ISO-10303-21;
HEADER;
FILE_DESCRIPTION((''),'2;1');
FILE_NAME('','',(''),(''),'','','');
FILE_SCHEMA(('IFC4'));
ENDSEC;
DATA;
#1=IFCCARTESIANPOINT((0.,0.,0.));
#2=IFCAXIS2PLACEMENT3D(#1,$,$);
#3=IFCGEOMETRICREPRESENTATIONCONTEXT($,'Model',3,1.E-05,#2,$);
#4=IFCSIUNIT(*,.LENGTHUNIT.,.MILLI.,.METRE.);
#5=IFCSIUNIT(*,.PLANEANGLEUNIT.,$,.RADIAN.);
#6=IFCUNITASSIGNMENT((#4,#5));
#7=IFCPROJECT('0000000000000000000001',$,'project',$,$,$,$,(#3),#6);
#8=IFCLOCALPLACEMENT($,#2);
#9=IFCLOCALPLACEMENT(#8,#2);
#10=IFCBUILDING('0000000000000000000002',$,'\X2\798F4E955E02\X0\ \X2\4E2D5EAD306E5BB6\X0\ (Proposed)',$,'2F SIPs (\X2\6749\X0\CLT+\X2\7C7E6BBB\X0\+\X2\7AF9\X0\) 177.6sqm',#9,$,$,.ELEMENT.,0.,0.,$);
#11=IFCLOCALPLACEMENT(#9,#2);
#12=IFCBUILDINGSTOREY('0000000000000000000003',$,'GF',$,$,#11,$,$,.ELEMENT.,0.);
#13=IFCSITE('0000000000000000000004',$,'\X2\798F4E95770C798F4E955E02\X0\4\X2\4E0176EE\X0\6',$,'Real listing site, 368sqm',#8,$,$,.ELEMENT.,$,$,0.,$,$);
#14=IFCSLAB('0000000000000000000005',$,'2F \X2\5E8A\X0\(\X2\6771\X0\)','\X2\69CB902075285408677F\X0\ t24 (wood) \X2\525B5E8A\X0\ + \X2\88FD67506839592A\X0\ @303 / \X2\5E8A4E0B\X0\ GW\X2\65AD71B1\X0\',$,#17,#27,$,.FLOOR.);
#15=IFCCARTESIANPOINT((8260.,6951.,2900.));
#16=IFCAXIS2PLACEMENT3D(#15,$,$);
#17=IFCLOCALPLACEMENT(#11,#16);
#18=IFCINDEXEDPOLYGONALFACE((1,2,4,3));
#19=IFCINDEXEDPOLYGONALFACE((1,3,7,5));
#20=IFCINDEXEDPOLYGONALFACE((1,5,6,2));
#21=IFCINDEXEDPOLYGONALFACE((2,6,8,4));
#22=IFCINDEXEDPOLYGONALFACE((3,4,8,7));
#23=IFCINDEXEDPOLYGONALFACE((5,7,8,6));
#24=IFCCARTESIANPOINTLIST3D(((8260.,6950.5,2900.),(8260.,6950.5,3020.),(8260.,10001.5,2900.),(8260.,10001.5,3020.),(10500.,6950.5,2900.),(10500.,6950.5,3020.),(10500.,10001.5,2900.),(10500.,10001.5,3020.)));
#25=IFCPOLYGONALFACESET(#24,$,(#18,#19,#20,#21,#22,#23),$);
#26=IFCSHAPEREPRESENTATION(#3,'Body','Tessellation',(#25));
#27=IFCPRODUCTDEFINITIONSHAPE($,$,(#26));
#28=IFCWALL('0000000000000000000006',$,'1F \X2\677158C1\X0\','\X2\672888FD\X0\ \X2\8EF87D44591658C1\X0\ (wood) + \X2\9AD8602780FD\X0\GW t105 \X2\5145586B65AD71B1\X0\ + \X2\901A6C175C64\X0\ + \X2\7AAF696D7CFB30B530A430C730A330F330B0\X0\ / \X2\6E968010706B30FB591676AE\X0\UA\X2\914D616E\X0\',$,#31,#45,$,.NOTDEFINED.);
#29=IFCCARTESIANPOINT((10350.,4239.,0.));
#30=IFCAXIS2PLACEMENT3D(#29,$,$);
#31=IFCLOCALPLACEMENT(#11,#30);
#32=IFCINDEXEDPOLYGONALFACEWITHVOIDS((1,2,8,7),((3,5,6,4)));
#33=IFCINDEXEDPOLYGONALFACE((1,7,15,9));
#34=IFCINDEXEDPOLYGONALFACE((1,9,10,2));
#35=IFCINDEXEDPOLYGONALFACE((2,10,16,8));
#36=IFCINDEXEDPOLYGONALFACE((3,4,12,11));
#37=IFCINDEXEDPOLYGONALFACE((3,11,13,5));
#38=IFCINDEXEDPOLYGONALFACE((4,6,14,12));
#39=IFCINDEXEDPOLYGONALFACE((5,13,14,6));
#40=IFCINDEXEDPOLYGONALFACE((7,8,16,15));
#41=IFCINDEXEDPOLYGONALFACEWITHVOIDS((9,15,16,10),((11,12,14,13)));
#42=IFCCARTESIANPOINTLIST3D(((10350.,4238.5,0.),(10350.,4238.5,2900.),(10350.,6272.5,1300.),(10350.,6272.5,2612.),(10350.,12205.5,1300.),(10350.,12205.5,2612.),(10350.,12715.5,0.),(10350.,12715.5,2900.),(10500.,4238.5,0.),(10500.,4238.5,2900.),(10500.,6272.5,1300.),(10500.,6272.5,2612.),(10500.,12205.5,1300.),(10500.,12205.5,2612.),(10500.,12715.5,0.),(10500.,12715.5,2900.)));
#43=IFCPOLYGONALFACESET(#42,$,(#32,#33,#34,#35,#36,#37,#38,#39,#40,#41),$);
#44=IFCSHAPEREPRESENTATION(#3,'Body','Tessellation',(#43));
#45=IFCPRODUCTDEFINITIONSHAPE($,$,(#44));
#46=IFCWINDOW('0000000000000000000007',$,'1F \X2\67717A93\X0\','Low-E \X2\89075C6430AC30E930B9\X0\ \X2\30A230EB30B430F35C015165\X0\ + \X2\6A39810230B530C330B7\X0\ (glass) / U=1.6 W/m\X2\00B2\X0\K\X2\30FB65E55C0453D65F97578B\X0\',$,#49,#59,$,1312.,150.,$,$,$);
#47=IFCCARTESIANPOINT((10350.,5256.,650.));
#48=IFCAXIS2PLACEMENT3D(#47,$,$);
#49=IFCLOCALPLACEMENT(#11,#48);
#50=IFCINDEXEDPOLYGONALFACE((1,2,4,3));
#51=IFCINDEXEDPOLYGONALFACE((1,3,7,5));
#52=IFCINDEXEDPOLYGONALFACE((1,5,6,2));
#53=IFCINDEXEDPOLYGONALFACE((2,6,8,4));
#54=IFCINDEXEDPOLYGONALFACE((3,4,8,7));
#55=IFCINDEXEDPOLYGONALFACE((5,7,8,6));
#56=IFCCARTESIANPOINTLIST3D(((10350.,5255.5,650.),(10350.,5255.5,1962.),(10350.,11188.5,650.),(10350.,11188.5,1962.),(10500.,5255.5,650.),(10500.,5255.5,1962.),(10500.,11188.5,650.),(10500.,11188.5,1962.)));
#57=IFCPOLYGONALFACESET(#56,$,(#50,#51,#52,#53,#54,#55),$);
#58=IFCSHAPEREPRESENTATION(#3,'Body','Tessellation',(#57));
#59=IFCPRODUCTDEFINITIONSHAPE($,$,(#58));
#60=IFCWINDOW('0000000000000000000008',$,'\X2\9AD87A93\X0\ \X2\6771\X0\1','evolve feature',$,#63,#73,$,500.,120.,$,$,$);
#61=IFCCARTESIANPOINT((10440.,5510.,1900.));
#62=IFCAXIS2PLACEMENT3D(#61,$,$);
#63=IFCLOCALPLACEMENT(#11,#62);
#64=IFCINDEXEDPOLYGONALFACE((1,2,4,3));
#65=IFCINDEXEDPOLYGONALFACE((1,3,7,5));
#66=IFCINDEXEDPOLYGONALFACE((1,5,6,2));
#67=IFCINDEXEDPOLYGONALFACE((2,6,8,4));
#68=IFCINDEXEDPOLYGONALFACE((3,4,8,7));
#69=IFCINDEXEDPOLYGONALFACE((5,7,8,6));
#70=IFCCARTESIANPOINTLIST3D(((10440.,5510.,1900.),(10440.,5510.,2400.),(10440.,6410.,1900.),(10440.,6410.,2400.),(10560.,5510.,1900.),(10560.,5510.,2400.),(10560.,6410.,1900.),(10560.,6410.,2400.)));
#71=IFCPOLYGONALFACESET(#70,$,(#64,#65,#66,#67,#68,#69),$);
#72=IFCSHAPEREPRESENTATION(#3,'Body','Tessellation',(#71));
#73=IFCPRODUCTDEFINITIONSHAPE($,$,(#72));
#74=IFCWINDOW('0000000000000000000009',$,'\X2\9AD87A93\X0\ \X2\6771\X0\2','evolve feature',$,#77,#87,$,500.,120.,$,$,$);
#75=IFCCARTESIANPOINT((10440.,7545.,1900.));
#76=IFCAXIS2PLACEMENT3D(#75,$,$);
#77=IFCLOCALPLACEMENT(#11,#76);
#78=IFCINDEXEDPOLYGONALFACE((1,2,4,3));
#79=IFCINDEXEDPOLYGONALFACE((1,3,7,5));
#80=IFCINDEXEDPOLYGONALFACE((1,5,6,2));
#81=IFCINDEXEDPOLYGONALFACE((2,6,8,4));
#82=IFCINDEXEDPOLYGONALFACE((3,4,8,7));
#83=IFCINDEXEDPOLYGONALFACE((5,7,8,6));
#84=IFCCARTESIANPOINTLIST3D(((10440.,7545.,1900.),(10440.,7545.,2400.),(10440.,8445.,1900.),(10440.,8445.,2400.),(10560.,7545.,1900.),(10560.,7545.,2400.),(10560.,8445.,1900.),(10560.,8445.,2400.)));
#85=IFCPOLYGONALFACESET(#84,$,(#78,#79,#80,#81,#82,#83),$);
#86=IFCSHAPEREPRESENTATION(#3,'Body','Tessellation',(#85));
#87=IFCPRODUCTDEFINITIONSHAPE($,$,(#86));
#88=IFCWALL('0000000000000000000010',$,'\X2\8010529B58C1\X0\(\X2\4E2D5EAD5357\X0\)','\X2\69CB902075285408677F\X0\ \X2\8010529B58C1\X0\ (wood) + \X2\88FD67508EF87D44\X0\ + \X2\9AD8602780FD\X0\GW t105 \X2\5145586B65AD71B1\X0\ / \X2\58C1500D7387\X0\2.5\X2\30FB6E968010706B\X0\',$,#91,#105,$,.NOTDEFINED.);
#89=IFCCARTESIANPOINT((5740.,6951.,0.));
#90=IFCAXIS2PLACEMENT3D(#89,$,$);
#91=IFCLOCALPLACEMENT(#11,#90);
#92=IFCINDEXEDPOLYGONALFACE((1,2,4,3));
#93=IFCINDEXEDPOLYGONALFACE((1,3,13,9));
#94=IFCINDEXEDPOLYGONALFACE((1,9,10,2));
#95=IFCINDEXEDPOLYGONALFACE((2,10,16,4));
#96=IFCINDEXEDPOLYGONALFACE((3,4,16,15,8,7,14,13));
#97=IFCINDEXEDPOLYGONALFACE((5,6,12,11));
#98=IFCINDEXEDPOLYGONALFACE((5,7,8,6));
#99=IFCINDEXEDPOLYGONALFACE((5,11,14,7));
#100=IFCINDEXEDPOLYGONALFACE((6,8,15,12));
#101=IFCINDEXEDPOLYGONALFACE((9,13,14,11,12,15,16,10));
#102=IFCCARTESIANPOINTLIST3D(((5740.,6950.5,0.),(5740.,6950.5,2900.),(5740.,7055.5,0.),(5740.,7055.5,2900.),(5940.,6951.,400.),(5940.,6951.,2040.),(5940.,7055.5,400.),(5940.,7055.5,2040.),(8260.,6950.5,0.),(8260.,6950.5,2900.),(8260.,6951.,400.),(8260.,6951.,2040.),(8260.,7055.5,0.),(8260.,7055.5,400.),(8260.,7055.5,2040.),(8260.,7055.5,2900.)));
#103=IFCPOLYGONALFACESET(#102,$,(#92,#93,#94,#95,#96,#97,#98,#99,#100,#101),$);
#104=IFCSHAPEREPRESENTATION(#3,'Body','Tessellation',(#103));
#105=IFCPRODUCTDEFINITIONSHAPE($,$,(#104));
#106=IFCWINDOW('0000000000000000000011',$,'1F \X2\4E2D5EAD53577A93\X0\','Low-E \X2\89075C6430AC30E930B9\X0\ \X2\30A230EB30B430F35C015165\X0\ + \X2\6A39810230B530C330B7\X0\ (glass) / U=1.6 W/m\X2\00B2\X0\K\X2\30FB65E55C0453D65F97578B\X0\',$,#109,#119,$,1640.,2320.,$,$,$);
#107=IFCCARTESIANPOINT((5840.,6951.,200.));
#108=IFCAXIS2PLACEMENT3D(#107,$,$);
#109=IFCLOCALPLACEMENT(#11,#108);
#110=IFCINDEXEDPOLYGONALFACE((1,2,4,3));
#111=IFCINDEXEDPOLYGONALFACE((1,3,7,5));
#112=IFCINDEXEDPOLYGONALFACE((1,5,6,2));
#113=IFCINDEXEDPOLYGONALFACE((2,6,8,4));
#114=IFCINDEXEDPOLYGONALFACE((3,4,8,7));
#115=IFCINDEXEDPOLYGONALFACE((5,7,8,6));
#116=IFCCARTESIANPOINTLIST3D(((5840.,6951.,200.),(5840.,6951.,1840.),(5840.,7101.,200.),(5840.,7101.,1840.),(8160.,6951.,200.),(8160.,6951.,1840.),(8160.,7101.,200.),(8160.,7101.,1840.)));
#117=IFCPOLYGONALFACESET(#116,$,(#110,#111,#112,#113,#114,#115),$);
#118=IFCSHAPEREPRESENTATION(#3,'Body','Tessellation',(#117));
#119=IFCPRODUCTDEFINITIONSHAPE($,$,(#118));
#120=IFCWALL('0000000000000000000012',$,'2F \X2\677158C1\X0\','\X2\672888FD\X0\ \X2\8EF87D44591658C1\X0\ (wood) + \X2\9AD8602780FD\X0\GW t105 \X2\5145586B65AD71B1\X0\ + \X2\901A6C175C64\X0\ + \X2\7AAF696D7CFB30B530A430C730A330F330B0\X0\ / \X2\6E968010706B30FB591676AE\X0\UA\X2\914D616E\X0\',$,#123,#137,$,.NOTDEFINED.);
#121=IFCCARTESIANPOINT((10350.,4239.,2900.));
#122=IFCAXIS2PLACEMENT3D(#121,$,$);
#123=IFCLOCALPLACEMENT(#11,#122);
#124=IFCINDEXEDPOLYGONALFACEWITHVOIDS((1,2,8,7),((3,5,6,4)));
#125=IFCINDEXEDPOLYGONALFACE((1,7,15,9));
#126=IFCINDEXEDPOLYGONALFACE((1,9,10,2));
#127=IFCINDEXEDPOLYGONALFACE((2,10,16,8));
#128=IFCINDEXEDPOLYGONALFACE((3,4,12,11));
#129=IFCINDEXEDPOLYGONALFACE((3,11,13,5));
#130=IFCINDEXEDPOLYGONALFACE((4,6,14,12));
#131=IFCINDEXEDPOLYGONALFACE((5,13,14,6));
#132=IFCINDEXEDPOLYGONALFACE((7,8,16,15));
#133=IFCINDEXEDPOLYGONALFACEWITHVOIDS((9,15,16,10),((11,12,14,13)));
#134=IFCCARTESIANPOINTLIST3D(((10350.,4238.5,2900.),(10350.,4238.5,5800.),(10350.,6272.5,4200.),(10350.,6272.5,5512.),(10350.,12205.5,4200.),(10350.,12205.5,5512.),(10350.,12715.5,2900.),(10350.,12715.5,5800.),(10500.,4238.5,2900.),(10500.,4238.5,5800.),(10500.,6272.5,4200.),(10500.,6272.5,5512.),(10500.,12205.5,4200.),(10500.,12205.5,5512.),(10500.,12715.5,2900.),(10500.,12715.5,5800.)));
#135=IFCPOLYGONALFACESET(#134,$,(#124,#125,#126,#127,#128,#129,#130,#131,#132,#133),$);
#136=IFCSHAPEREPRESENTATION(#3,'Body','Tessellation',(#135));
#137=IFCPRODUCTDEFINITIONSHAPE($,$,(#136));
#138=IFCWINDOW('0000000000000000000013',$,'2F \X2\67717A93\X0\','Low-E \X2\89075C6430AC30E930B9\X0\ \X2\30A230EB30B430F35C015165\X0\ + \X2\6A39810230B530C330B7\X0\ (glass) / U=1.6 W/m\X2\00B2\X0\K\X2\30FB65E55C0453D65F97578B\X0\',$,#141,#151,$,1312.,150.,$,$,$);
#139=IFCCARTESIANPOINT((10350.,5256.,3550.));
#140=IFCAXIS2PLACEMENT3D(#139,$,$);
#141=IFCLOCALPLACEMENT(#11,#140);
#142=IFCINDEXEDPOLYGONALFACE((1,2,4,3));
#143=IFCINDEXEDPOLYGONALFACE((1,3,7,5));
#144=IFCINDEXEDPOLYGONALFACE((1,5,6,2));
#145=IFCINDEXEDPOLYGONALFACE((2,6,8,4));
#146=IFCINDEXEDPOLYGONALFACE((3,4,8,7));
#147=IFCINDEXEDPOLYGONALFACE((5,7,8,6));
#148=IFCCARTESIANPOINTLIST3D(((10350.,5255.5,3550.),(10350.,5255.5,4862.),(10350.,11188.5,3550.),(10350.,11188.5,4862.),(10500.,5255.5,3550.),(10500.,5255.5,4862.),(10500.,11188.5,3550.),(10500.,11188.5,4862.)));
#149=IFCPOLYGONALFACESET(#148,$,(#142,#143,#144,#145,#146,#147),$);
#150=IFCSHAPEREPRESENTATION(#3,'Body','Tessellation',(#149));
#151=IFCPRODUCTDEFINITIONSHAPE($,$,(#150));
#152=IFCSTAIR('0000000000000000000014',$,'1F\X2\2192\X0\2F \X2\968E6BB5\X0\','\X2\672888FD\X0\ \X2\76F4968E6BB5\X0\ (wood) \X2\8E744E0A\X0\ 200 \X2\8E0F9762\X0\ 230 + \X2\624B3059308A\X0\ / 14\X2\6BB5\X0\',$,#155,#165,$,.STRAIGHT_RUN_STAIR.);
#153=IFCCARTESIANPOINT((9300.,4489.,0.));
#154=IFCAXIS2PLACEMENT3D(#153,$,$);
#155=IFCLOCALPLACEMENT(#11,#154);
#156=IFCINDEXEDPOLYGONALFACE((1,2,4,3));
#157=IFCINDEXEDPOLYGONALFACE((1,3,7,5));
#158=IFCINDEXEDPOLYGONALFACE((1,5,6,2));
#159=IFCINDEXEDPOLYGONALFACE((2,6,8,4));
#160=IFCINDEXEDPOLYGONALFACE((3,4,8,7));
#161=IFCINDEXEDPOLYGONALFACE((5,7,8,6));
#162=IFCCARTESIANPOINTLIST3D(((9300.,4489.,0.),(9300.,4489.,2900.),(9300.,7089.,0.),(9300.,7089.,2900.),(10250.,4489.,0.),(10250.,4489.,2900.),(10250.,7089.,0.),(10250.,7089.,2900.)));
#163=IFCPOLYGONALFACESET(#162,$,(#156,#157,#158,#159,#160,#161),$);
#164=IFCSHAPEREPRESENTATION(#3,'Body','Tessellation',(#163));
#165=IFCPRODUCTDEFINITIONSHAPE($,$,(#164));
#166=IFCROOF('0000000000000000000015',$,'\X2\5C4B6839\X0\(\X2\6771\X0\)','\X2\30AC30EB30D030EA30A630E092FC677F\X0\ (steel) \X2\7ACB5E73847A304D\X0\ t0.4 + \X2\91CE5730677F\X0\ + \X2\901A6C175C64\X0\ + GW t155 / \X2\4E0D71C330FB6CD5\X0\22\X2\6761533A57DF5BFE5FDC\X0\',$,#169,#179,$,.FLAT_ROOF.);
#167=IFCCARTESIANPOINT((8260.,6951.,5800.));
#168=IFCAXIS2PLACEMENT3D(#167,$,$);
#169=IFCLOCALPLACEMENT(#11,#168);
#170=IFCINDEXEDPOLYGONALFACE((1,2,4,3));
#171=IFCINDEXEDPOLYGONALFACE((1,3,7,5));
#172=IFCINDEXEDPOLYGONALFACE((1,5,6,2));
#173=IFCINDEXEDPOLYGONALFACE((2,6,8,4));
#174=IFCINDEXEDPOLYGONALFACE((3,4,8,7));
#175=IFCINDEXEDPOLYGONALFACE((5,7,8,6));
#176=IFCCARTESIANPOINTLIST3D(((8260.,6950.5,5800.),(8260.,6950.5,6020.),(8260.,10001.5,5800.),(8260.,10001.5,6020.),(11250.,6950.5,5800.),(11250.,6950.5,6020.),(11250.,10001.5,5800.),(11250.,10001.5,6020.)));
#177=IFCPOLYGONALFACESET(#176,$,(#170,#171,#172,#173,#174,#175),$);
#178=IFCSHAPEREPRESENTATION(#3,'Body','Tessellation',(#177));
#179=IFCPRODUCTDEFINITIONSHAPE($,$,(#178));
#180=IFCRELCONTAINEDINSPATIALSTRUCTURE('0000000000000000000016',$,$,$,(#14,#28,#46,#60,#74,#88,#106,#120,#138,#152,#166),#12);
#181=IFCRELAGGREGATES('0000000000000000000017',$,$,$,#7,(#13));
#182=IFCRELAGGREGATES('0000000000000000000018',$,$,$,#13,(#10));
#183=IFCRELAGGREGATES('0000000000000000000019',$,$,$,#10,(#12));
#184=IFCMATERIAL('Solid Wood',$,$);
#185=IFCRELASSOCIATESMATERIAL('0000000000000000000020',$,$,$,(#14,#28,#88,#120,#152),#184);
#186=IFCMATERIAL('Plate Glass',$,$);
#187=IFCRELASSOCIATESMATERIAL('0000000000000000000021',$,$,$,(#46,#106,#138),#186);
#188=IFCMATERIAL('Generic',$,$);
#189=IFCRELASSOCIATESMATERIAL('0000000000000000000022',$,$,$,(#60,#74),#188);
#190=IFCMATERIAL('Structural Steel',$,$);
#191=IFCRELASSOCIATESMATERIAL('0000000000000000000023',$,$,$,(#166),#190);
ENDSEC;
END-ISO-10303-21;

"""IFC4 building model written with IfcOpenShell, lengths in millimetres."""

from ifc_helpers import new_model, si_unit, frame, frame_2d, origin, place, context, project, spatial, rectangle, extrude, material, element, fill, save


model = new_model("IFC4")

# Units and contexts
model_context = context("Model", 3, precision=1e-05, world=origin())
ifc_project = project(units=[si_unit("LENGTHUNIT", "METRE", prefix="MILLI"), si_unit("PLANEANGLEUNIT", "RADIAN")], contexts=[model_context])

# Site, building, storey
site_placement = place(None, origin())
site = spatial("IfcSite", under=ifc_project, at=site_placement, Name="福井県福井市4丁目6", ObjectType="Real listing site, 368sqm", CompositionType="ELEMENT", RefElevation=0.0)
building_placement = place(site_placement, origin())
building = spatial("IfcBuilding", under=site, at=building_placement, Name="福井市 中庭の家 (Proposed)", ObjectType="2F SIPs (杉CLT+籾殻+竹) 177.6sqm", CompositionType="ELEMENT", ElevationOfRefHeight=0.0, ElevationOfTerrain=0.0)
storey_placement = place(building_placement, origin())
storey = spatial("IfcBuildingStorey", under=building, at=storey_placement, Name="GF", CompositionType="ELEMENT", Elevation=0.0)

# Slab
ifc_material_1 = material(Name="Solid Wood")
slab_1_placement = place(storey_placement, frame((8260.0, 6951.0, 2900.0)))
element("IfcSlab", 1, at=slab_1_placement, inside=storey, material=ifc_material_1, Name="2F 床(東)", Description="構造用合板 t24 (wood) 剛床 + 製材根太 @303 / 床下 GW断熱", PredefinedType="FLOOR", context=model_context, shape_type="SweptSolid", body=[
    extrude(rectangle(XDim=2240.0, YDim=3051.0, at=frame_2d((1120.0, 1525.0))), frame((8260.0, 6951.0, 2900.0)), (0.0, 0.0, 1.0), 120.0),
])

# Wall, openings, windows
wall_1_placement = place(storey_placement, frame((10350.0, 4239.0, 0.0)))
wall_1 = element("IfcWall", 2, at=wall_1_placement, inside=storey, material=ifc_material_1, Name="1F 東壁", Description="木製 軸組外壁 (wood) + 高性能GW t105 充填断熱 + 通気層 + 窯業系サイディング / 準耐火・外皮UA配慮", PredefinedType="NOTDEFINED", context=model_context, shape_type="SweptSolid", body=[
    extrude(rectangle(XDim=150.0, YDim=8477.0, at=frame_2d((75.0, 4238.0))), frame((10350.0, 4239.0, 0.0)), (0.0, 0.0, 1.0), 2900.0),
])
opening_1_placement = place(storey_placement, frame((10350.0, 5256.0, 650.0)))
opening_1 = element("IfcOpeningElement", 3, at=opening_1_placement, cuts=wall_1, PredefinedType="NOTDEFINED", context=model_context, shape_type="SweptSolid", body=[
    extrude(rectangle(XDim=150.0, YDim=5933.0, at=frame_2d((75.0, 2966.0))), frame((10350.0, 5256.0, 650.0)), (0.0, 0.0, 1.0), 1312.0),
])
opening_2_placement = place(storey_placement, frame((10440.0, 5510.0, 1900.0)))
opening_2 = element("IfcOpeningElement", 4, at=opening_2_placement, cuts=wall_1, PredefinedType="NOTDEFINED", context=model_context, shape_type="SweptSolid", body=[
    extrude(rectangle(XDim=120.0, YDim=900.0, at=frame_2d((60.0, 450.0))), frame((10440.0, 5510.0, 1900.0)), (0.0, 0.0, 1.0), 500.0),
])
opening_3_placement = place(storey_placement, frame((10440.0, 7545.0, 1900.0)))
opening_3 = element("IfcOpeningElement", 5, at=opening_3_placement, cuts=wall_1, PredefinedType="NOTDEFINED", context=model_context, shape_type="SweptSolid", body=[
    extrude(rectangle(XDim=120.0, YDim=900.0, at=frame_2d((60.0, 450.0))), frame((10440.0, 7545.0, 1900.0)), (0.0, 0.0, 1.0), 500.0),
])
ifc_material_2 = material(Name="Plate Glass")
window_1_placement = place(storey_placement, frame((10350.0, 5256.0, 650.0)))
window_1 = element("IfcWindow", 6, at=window_1_placement, inside=storey, material=ifc_material_2, Name="1F 東窓", Description="Low-E 複層ガラス アルゴン封入 + 樹脂サッシ (glass) / U=1.6 W/m²K・日射取得型", OverallHeight=1312.0, OverallWidth=150.0, context=model_context, shape_type="SweptSolid", body=[
    extrude(rectangle(XDim=150.0, YDim=5933.0, at=frame_2d((75.0, 2966.0))), frame((10350.0, 5256.0, 650.0)), (0.0, 0.0, 1.0), 1312.0),
])
fill(opening_1, window_1)
ifc_material_3 = material(Name="Generic")
window_2_placement = place(storey_placement, frame((10440.0, 5510.0, 1900.0)))
window_2 = element("IfcWindow", 7, at=window_2_placement, inside=storey, material=ifc_material_3, Name="高窓 東1", Description="evolve feature", OverallHeight=500.0, OverallWidth=120.0, context=model_context, shape_type="SweptSolid", body=[
    extrude(rectangle(XDim=120.0, YDim=900.0, at=frame_2d((60.0, 450.0))), frame((10440.0, 5510.0, 1900.0)), (0.0, 0.0, 1.0), 500.0),
])
fill(opening_2, window_2)
window_3_placement = place(storey_placement, frame((10440.0, 7545.0, 1900.0)))
window_3 = element("IfcWindow", 8, at=window_3_placement, inside=storey, material=ifc_material_3, Name="高窓 東2", Description="evolve feature", OverallHeight=500.0, OverallWidth=120.0, context=model_context, shape_type="SweptSolid", body=[
    extrude(rectangle(XDim=120.0, YDim=900.0, at=frame_2d((60.0, 450.0))), frame((10440.0, 7545.0, 1900.0)), (0.0, 0.0, 1.0), 500.0),
])
fill(opening_3, window_3)

# Wall, opening, window
wall_2_placement = place(storey_placement, frame((5740.0, 6951.0, 0.0)))
wall_2 = element("IfcWall", 9, at=wall_2_placement, inside=storey, material=ifc_material_1, Name="耐力壁(中庭南)", Description="構造用合板 耐力壁 (wood) + 製材軸組 + 高性能GW t105 充填断熱 / 壁倍率2.5・準耐火", PredefinedType="NOTDEFINED", context=model_context, shape_type="SweptSolid", body=[
    extrude(rectangle(XDim=2520.0, YDim=105.0, at=frame_2d((1260.0, 52.0))), frame((5740.0, 6951.0, 0.0)), (0.0, 0.0, 1.0), 2900.0),
])
opening_4_placement = place(storey_placement, frame((5840.0, 6951.0, 200.0)))
opening_4 = element("IfcOpeningElement", 10, at=opening_4_placement, cuts=wall_2, PredefinedType="NOTDEFINED", context=model_context, shape_type="SweptSolid", body=[
    extrude(rectangle(XDim=2320.0, YDim=150.0, at=frame_2d((1160.0, 75.0))), frame((5840.0, 6951.0, 200.0)), (0.0, 0.0, 1.0), 1640.0),
])
window_4_placement = place(storey_placement, frame((5840.0, 6951.0, 200.0)))
window_4 = element("IfcWindow", 11, at=window_4_placement, inside=storey, material=ifc_material_2, Name="1F 中庭南窓", Description="Low-E 複層ガラス アルゴン封入 + 樹脂サッシ (glass) / U=1.6 W/m²K・日射取得型", OverallHeight=1640.0, OverallWidth=2320.0, context=model_context, shape_type="SweptSolid", body=[
    extrude(rectangle(XDim=2320.0, YDim=150.0, at=frame_2d((1160.0, 75.0))), frame((5840.0, 6951.0, 200.0)), (0.0, 0.0, 1.0), 1640.0),
])
fill(opening_4, window_4)

# Wall, opening, window
wall_3_placement = place(storey_placement, frame((10350.0, 4239.0, 2900.0)))
wall_3 = element("IfcWall", 12, at=wall_3_placement, inside=storey, material=ifc_material_1, Name="2F 東壁", Description="木製 軸組外壁 (wood) + 高性能GW t105 充填断熱 + 通気層 + 窯業系サイディング / 準耐火・外皮UA配慮", PredefinedType="NOTDEFINED", context=model_context, shape_type="SweptSolid", body=[
    extrude(rectangle(XDim=150.0, YDim=8477.0, at=frame_2d((75.0, 4238.0))), frame((10350.0, 4239.0, 2900.0)), (0.0, 0.0, 1.0), 2900.0),
])
opening_5_placement = place(storey_placement, frame((10350.0, 5256.0, 3550.0)))
opening_5 = element("IfcOpeningElement", 13, at=opening_5_placement, cuts=wall_3, PredefinedType="NOTDEFINED", context=model_context, shape_type="SweptSolid", body=[
    extrude(rectangle(XDim=150.0, YDim=5933.0, at=frame_2d((75.0, 2966.0))), frame((10350.0, 5256.0, 3550.0)), (0.0, 0.0, 1.0), 1312.0),
])
window_5_placement = place(storey_placement, frame((10350.0, 5256.0, 3550.0)))
window_5 = element("IfcWindow", 14, at=window_5_placement, inside=storey, material=ifc_material_2, Name="2F 東窓", Description="Low-E 複層ガラス アルゴン封入 + 樹脂サッシ (glass) / U=1.6 W/m²K・日射取得型", OverallHeight=1312.0, OverallWidth=150.0, context=model_context, shape_type="SweptSolid", body=[
    extrude(rectangle(XDim=150.0, YDim=5933.0, at=frame_2d((75.0, 2966.0))), frame((10350.0, 5256.0, 3550.0)), (0.0, 0.0, 1.0), 1312.0),
])
fill(opening_5, window_5)

# Stair
stair_placement = place(storey_placement, frame((9300.0, 4489.0, 0.0)))
element("IfcStair", 15, at=stair_placement, inside=storey, material=ifc_material_1, Name="1F→2F 階段", Description="木製 直階段 (wood) 蹴上 200 踏面 230 + 手すり / 14段", PredefinedType="STRAIGHT_RUN_STAIR", context=model_context, shape_type="SweptSolid", body=[
    extrude(rectangle(XDim=950.0, YDim=2600.0, at=frame_2d((475.0, 1300.0))), frame((9300.0, 4489.0, 0.0)), (0.0, 0.0, 1.0), 2900.0),
])

# Roof
ifc_material_4 = material(Name="Structural Steel")
roof_placement = place(storey_placement, frame((8260.0, 6951.0, 5800.0)))
element("IfcRoof", 16, at=roof_placement, inside=storey, material=ifc_material_4, Name="屋根(東)", Description="ガルバリウム鋼板 (steel) 立平葺き t0.4 + 野地板 + 通気層 + GW t155 / 不燃・法22条区域対応", PredefinedType="FLAT_ROOF", context=model_context, shape_type="SweptSolid", body=[
    extrude(rectangle(XDim=2990.0, YDim=3051.0, at=frame_2d((1495.0, 1525.0))), frame((8260.0, 6951.0, 5800.0)), (0.0, 0.0, 1.0), 220.0),
])

save(model, "model.ifc")
